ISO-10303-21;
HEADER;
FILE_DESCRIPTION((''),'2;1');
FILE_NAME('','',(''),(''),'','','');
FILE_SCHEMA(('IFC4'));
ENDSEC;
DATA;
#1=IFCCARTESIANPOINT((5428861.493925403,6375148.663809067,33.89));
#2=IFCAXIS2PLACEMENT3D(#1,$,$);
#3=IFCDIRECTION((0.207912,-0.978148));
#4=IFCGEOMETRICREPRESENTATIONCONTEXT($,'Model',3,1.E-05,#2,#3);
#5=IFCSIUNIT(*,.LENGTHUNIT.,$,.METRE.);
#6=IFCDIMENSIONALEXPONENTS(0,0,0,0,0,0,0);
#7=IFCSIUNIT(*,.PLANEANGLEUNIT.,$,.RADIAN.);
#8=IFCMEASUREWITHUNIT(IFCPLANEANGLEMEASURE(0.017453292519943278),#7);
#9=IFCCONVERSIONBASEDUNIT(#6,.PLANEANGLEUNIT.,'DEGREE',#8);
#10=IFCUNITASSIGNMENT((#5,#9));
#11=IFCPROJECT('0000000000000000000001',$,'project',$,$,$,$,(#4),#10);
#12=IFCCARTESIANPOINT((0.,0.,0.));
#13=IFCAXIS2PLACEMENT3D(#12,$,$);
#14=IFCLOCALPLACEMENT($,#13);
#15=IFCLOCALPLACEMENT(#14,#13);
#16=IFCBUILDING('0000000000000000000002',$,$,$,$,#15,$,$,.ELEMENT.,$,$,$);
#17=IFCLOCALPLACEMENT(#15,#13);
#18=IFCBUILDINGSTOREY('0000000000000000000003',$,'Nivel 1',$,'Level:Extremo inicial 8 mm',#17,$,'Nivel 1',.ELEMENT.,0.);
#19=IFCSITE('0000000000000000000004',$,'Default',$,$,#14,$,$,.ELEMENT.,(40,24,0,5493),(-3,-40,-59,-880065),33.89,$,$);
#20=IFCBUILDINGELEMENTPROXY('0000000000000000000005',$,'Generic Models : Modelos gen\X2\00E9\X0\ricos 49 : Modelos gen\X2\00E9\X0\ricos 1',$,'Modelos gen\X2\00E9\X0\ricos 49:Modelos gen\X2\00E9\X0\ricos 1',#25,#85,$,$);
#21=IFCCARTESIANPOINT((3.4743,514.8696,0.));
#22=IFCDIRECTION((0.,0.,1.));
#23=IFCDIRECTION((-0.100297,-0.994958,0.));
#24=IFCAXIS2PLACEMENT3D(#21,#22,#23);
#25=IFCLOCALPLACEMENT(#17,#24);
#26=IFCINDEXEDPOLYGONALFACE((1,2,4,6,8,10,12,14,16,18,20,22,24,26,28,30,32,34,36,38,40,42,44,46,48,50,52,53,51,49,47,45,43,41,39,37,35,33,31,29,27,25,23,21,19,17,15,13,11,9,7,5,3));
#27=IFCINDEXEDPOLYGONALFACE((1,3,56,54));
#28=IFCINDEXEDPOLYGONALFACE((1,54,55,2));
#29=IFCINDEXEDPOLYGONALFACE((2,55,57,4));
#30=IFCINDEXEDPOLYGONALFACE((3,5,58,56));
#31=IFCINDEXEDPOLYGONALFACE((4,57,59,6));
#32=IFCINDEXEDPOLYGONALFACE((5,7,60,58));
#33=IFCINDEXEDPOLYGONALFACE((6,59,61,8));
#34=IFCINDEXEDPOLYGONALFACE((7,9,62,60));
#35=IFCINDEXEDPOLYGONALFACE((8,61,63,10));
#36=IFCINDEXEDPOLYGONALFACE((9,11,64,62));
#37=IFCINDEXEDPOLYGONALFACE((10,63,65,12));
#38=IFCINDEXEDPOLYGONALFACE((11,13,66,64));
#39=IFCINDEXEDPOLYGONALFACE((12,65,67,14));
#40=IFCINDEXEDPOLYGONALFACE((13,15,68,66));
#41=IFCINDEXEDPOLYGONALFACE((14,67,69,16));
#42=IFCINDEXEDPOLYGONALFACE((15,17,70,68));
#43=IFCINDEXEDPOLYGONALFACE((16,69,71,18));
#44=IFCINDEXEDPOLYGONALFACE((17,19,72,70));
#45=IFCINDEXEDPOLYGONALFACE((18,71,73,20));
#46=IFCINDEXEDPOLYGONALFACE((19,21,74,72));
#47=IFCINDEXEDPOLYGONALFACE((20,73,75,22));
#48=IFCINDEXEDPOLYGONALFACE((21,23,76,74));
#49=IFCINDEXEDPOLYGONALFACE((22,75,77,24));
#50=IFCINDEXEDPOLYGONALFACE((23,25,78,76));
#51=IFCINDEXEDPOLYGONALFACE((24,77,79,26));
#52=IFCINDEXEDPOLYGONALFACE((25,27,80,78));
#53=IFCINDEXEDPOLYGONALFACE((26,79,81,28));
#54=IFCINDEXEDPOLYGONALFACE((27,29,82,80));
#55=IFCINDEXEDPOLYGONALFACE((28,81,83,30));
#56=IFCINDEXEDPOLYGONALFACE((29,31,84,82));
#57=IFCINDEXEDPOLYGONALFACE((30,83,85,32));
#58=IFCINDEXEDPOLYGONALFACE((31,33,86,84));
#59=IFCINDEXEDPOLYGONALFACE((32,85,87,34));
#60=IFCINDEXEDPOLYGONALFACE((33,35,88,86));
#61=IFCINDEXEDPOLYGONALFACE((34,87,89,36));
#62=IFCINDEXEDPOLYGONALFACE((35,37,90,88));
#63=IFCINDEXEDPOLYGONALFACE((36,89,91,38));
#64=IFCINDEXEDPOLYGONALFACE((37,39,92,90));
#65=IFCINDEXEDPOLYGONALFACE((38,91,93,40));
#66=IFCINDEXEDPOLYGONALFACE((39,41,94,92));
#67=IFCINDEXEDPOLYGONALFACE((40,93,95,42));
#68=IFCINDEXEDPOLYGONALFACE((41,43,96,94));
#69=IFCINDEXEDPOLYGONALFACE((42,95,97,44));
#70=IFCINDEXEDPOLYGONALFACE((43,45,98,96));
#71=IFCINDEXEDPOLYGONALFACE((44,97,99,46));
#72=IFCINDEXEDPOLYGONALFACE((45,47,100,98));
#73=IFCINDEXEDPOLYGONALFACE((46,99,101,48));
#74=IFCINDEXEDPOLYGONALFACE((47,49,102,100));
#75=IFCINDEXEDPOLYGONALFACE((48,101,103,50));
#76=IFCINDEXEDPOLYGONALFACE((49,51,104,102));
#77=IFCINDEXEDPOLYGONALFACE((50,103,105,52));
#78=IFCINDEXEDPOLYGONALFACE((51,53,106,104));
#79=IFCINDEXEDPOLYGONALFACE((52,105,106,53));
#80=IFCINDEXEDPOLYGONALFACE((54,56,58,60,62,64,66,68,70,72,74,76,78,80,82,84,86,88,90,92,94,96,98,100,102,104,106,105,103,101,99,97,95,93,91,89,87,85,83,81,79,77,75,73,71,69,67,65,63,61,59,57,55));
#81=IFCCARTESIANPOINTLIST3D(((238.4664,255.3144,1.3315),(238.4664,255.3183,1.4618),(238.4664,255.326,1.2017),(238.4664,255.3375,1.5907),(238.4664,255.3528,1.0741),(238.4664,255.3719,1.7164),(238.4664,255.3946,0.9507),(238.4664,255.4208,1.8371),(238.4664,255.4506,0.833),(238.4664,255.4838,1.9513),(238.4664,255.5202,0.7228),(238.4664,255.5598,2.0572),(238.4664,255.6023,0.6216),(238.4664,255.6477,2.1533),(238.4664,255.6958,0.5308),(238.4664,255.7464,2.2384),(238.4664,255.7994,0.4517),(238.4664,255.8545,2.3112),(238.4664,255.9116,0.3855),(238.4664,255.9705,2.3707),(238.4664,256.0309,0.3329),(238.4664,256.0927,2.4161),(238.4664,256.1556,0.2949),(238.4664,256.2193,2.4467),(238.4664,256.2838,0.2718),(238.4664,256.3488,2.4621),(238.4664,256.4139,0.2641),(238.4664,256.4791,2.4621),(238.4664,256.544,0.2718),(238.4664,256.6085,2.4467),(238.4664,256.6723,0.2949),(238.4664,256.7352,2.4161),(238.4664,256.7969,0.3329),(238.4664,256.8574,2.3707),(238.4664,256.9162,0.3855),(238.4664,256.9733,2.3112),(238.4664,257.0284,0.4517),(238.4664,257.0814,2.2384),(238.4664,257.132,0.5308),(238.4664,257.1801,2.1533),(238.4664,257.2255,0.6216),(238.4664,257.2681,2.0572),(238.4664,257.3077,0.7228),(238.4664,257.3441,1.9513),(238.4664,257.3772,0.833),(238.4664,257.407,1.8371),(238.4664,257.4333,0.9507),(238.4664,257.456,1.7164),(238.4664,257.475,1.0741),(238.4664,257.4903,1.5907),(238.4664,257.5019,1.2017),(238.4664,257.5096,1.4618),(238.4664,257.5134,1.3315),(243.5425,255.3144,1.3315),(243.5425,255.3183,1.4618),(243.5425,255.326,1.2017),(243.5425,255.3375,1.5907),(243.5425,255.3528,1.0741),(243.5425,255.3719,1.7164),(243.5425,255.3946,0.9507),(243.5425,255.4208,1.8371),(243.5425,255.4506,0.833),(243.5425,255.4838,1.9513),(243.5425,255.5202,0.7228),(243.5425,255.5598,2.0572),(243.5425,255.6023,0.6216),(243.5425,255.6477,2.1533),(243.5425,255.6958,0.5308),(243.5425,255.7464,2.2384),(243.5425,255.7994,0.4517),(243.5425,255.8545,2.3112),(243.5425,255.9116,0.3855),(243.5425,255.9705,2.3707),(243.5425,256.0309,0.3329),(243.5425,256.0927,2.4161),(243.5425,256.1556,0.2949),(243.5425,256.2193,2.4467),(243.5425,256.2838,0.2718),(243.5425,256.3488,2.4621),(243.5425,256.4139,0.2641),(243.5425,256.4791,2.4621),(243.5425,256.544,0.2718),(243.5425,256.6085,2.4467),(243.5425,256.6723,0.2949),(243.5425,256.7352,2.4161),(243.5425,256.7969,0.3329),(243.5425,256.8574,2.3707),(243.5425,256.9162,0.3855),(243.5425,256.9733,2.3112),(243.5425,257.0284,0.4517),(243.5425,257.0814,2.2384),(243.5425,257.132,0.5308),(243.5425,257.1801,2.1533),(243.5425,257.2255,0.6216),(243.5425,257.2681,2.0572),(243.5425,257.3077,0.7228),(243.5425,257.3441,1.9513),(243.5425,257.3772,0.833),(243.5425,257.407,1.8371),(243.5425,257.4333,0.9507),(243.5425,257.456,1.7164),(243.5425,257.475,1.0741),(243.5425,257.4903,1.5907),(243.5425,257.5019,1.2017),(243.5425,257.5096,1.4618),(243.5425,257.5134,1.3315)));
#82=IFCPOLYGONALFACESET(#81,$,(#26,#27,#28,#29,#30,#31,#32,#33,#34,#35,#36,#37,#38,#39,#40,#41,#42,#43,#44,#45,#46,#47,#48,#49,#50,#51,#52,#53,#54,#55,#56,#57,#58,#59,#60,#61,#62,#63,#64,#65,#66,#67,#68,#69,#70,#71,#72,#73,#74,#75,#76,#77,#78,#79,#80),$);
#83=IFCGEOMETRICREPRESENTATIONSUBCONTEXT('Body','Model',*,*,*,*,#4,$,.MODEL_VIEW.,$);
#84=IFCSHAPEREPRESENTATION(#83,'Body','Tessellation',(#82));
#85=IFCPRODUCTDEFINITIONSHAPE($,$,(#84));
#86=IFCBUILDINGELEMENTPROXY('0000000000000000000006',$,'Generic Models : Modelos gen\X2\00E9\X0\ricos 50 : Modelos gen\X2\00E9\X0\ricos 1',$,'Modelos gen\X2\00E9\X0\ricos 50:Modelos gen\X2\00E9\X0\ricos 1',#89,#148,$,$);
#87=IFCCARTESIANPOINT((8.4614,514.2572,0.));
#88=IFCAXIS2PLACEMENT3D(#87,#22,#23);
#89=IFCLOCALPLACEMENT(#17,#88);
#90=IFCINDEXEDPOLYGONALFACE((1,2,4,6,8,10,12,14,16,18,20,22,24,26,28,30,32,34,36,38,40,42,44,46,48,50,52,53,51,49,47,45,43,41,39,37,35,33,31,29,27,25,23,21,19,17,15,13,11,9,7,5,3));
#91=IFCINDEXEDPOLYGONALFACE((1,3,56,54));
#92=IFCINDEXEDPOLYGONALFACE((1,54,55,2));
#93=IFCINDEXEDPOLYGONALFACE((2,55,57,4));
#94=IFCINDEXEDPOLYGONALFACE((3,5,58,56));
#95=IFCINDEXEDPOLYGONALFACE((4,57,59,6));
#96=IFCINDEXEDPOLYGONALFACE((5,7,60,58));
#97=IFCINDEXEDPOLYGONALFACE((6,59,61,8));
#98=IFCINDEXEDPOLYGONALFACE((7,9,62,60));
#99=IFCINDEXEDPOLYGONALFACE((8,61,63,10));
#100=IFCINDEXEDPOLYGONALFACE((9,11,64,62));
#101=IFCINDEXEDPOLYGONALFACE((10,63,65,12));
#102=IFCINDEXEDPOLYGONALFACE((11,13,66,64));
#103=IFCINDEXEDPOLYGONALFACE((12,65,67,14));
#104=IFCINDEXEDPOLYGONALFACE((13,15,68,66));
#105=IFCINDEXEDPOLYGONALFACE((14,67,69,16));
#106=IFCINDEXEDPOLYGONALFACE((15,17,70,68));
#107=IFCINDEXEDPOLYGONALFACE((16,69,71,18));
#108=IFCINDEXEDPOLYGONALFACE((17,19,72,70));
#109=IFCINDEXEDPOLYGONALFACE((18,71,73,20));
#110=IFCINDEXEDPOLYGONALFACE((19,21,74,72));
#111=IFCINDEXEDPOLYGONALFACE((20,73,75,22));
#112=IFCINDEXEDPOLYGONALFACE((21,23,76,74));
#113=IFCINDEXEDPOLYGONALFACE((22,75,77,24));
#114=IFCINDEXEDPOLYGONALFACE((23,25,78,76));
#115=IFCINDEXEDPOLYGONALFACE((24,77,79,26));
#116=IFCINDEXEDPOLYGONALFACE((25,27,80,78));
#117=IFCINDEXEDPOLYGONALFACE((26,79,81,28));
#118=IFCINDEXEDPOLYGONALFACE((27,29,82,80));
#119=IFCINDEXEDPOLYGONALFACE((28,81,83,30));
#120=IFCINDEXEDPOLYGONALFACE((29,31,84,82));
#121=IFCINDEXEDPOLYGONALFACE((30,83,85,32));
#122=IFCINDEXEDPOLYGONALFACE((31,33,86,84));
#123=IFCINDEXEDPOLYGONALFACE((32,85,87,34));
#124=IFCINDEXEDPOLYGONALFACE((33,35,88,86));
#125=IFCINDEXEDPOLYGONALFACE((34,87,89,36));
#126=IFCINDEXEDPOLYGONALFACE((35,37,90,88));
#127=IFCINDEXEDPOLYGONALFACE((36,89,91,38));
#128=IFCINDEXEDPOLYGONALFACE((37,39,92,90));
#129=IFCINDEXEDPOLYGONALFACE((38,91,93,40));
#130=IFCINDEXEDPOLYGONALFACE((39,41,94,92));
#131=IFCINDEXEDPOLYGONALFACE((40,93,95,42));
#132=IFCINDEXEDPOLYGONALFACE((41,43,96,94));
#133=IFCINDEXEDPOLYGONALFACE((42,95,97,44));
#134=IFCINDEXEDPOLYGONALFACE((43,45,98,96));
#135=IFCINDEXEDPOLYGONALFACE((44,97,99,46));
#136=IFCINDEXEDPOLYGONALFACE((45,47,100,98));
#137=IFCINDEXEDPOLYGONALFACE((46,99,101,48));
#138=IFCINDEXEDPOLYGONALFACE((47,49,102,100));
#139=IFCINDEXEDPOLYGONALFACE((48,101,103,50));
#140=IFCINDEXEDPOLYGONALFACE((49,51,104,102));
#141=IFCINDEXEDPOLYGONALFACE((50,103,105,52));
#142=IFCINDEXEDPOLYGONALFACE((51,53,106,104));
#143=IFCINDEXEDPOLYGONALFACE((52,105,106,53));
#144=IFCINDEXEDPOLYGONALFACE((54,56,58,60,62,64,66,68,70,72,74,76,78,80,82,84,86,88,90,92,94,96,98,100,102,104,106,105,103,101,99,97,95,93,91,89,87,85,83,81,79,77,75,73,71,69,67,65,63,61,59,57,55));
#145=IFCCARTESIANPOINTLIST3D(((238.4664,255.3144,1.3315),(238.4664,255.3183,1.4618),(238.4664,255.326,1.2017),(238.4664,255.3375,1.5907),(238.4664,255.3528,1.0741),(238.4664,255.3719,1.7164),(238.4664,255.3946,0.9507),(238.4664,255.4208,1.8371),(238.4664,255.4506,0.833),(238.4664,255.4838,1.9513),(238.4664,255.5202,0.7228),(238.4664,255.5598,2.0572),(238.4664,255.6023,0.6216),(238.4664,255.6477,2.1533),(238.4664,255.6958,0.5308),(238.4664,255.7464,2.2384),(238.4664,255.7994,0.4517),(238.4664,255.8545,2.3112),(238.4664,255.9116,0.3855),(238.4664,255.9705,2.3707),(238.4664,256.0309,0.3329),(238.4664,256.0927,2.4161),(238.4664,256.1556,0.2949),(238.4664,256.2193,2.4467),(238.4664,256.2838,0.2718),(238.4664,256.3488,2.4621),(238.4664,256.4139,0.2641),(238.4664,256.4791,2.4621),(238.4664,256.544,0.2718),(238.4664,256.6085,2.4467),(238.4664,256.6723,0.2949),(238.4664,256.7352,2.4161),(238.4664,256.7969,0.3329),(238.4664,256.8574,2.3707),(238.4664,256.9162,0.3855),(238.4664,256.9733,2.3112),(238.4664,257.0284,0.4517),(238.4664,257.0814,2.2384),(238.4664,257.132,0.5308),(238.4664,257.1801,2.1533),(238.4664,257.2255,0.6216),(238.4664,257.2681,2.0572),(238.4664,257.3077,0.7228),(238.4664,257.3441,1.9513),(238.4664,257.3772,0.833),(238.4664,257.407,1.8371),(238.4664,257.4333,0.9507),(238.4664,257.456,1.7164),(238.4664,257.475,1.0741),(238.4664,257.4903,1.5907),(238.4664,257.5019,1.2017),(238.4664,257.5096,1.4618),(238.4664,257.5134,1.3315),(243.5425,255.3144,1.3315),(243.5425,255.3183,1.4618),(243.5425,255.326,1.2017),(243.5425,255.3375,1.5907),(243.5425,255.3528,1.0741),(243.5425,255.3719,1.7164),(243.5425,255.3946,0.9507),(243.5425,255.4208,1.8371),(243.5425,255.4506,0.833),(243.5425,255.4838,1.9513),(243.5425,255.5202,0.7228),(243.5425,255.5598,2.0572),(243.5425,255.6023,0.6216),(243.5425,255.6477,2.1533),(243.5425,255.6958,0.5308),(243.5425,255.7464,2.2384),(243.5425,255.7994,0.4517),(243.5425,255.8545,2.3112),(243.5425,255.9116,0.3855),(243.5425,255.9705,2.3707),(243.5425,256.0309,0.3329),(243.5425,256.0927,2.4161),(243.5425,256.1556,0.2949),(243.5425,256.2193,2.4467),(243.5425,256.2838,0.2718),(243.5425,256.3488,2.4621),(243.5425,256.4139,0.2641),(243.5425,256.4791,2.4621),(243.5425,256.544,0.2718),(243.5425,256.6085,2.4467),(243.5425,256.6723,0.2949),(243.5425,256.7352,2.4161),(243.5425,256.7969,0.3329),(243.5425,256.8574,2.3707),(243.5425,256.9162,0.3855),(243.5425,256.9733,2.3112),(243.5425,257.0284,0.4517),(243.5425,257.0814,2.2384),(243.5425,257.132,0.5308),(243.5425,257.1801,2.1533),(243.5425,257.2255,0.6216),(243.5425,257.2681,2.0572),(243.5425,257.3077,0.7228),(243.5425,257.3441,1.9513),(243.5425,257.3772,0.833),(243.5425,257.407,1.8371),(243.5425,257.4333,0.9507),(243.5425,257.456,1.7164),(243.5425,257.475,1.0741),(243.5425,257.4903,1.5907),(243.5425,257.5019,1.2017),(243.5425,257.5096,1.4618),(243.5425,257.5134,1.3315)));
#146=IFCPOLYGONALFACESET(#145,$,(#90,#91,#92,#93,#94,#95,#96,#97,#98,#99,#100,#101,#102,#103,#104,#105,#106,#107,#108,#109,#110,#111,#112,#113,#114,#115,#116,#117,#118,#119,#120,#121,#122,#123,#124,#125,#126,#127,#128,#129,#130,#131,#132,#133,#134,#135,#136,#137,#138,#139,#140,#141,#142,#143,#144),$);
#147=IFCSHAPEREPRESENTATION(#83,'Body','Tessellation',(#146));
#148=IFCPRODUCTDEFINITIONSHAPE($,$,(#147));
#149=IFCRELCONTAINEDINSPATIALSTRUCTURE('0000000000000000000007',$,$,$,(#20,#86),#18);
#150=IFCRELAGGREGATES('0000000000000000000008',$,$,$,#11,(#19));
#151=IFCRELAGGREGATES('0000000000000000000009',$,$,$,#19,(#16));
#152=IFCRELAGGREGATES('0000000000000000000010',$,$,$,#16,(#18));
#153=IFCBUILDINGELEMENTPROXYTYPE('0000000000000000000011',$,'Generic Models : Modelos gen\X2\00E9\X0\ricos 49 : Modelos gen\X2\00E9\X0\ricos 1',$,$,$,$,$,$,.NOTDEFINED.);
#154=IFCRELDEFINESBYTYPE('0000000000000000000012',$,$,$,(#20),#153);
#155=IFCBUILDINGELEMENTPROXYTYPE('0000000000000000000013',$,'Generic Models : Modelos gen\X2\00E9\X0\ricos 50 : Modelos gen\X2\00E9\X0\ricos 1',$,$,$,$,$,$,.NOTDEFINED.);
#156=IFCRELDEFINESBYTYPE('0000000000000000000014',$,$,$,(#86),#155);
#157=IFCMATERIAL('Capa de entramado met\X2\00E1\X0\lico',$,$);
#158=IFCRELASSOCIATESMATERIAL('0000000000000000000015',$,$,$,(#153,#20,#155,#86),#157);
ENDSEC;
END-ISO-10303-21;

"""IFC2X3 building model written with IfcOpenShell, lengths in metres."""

from ifc_helpers import new_model, entity, si_unit, converted_unit, direction, frame, origin, origin_2d_with_axis, place, context, subcontext, project, spatial, circle, extrude, source, transform, mapped, material, type_object, type_shapes, element, save


model = new_model("IFC2X3")

# Units and contexts
model_context = context("Model", 3, precision=1e-05, world=frame((5428861.493925403, 6375148.663809067, 33.89)), true_north=direction((0.207912, -0.978148)))
body_context = subcontext(model_context, "Body", "Model", "MODEL_VIEW")
ifc_project = project(units=[si_unit("LENGTHUNIT", "METRE"), converted_unit("PLANEANGLEUNIT", "DEGREE", entity("IfcPlaneAngleMeasure", 0.017453292519943278), si_unit("PLANEANGLEUNIT", "RADIAN"), dimensions=[0, 0, 0, 0, 0, 0, 0])], contexts=[model_context])

# Site, building, storey
site_placement = place(None, origin())
site = spatial("IfcSite", under=ifc_project, at=site_placement, Name="Default", CompositionType="ELEMENT", RefLatitude=(40, 24, 0, 5493), RefLongitude=(-3, -40, -59, -880065), RefElevation=33.89)
building_placement = place(site_placement, origin())
building = spatial("IfcBuilding", under=site, at=building_placement, CompositionType="ELEMENT")
storey_placement = place(building_placement, origin())
storey = spatial("IfcBuildingStorey", under=building, at=storey_placement, Name="Nivel 1", ObjectType="Level:Extremo inicial 8 mm", LongName="Nivel 1", CompositionType="ELEMENT", Elevation=0.0)

# Building element proxies
ifc_material_1 = material(Name="Capa de entramado metálico")
building_element_proxy_type_1 = type_object("IfcBuildingElementProxyType", Name="Generic Models : Modelos genéricos 49 : Modelos genéricos 1", PredefinedType="NOTDEFINED", material=ifc_material_1)
shared_shape_1 = source(origin(), body_context, "Body", "SweptSolid", [
    extrude(circle(Radius=1.1, at=origin_2d_with_axis()), frame((238.4664, 256.4139, 1.3641), z_axis=(1.0, 0.0, 0.0), x_axis=(0.0, 0.0, -1.0)), (0.0, 0.0, 1.0), 5.0761),
])
type_shapes(building_element_proxy_type_1, [shared_shape_1])
proxy_1_placement = place(storey_placement, frame((3.4743, 514.8696, 0.0), z_axis=(0.0, 0.0, 1.0), x_axis=(-0.100297, -0.994958, 0.0)))
element("IfcBuildingElementProxy", 1, at=proxy_1_placement, inside=storey, type_object=building_element_proxy_type_1, material=ifc_material_1, Name="Generic Models : Modelos genéricos 49 : Modelos genéricos 1", ObjectType="Modelos genéricos 49:Modelos genéricos 1", context=body_context, shape_type="MappedRepresentation", body=[
    mapped(shared_shape_1, transform((0.0, 0.0, 0.0), scale=1.0)),
])
building_element_proxy_type_2 = type_object("IfcBuildingElementProxyType", Name="Generic Models : Modelos genéricos 50 : Modelos genéricos 1", PredefinedType="NOTDEFINED", material=ifc_material_1)
shared_shape_2 = source(origin(), body_context, "Body", "SweptSolid", [
    extrude(circle(Radius=1.1, at=origin_2d_with_axis()), frame((238.4664, 256.4139, 1.3641), z_axis=(1.0, 0.0, 0.0), x_axis=(0.0, 0.0, -1.0)), (0.0, 0.0, 1.0), 5.0761),
])
type_shapes(building_element_proxy_type_2, [shared_shape_2])
proxy_2_placement = place(storey_placement, frame((8.4614, 514.2572, 0.0), z_axis=(0.0, 0.0, 1.0), x_axis=(-0.100297, -0.994958, 0.0)))
element("IfcBuildingElementProxy", 2, at=proxy_2_placement, inside=storey, type_object=building_element_proxy_type_2, material=ifc_material_1, Name="Generic Models : Modelos genéricos 50 : Modelos genéricos 1", ObjectType="Modelos genéricos 50:Modelos genéricos 1", context=body_context, shape_type="MappedRepresentation", body=[
    mapped(shared_shape_2, transform((0.0, 0.0, 0.0), scale=1.0)),
])

save(model, "model.ifc")
